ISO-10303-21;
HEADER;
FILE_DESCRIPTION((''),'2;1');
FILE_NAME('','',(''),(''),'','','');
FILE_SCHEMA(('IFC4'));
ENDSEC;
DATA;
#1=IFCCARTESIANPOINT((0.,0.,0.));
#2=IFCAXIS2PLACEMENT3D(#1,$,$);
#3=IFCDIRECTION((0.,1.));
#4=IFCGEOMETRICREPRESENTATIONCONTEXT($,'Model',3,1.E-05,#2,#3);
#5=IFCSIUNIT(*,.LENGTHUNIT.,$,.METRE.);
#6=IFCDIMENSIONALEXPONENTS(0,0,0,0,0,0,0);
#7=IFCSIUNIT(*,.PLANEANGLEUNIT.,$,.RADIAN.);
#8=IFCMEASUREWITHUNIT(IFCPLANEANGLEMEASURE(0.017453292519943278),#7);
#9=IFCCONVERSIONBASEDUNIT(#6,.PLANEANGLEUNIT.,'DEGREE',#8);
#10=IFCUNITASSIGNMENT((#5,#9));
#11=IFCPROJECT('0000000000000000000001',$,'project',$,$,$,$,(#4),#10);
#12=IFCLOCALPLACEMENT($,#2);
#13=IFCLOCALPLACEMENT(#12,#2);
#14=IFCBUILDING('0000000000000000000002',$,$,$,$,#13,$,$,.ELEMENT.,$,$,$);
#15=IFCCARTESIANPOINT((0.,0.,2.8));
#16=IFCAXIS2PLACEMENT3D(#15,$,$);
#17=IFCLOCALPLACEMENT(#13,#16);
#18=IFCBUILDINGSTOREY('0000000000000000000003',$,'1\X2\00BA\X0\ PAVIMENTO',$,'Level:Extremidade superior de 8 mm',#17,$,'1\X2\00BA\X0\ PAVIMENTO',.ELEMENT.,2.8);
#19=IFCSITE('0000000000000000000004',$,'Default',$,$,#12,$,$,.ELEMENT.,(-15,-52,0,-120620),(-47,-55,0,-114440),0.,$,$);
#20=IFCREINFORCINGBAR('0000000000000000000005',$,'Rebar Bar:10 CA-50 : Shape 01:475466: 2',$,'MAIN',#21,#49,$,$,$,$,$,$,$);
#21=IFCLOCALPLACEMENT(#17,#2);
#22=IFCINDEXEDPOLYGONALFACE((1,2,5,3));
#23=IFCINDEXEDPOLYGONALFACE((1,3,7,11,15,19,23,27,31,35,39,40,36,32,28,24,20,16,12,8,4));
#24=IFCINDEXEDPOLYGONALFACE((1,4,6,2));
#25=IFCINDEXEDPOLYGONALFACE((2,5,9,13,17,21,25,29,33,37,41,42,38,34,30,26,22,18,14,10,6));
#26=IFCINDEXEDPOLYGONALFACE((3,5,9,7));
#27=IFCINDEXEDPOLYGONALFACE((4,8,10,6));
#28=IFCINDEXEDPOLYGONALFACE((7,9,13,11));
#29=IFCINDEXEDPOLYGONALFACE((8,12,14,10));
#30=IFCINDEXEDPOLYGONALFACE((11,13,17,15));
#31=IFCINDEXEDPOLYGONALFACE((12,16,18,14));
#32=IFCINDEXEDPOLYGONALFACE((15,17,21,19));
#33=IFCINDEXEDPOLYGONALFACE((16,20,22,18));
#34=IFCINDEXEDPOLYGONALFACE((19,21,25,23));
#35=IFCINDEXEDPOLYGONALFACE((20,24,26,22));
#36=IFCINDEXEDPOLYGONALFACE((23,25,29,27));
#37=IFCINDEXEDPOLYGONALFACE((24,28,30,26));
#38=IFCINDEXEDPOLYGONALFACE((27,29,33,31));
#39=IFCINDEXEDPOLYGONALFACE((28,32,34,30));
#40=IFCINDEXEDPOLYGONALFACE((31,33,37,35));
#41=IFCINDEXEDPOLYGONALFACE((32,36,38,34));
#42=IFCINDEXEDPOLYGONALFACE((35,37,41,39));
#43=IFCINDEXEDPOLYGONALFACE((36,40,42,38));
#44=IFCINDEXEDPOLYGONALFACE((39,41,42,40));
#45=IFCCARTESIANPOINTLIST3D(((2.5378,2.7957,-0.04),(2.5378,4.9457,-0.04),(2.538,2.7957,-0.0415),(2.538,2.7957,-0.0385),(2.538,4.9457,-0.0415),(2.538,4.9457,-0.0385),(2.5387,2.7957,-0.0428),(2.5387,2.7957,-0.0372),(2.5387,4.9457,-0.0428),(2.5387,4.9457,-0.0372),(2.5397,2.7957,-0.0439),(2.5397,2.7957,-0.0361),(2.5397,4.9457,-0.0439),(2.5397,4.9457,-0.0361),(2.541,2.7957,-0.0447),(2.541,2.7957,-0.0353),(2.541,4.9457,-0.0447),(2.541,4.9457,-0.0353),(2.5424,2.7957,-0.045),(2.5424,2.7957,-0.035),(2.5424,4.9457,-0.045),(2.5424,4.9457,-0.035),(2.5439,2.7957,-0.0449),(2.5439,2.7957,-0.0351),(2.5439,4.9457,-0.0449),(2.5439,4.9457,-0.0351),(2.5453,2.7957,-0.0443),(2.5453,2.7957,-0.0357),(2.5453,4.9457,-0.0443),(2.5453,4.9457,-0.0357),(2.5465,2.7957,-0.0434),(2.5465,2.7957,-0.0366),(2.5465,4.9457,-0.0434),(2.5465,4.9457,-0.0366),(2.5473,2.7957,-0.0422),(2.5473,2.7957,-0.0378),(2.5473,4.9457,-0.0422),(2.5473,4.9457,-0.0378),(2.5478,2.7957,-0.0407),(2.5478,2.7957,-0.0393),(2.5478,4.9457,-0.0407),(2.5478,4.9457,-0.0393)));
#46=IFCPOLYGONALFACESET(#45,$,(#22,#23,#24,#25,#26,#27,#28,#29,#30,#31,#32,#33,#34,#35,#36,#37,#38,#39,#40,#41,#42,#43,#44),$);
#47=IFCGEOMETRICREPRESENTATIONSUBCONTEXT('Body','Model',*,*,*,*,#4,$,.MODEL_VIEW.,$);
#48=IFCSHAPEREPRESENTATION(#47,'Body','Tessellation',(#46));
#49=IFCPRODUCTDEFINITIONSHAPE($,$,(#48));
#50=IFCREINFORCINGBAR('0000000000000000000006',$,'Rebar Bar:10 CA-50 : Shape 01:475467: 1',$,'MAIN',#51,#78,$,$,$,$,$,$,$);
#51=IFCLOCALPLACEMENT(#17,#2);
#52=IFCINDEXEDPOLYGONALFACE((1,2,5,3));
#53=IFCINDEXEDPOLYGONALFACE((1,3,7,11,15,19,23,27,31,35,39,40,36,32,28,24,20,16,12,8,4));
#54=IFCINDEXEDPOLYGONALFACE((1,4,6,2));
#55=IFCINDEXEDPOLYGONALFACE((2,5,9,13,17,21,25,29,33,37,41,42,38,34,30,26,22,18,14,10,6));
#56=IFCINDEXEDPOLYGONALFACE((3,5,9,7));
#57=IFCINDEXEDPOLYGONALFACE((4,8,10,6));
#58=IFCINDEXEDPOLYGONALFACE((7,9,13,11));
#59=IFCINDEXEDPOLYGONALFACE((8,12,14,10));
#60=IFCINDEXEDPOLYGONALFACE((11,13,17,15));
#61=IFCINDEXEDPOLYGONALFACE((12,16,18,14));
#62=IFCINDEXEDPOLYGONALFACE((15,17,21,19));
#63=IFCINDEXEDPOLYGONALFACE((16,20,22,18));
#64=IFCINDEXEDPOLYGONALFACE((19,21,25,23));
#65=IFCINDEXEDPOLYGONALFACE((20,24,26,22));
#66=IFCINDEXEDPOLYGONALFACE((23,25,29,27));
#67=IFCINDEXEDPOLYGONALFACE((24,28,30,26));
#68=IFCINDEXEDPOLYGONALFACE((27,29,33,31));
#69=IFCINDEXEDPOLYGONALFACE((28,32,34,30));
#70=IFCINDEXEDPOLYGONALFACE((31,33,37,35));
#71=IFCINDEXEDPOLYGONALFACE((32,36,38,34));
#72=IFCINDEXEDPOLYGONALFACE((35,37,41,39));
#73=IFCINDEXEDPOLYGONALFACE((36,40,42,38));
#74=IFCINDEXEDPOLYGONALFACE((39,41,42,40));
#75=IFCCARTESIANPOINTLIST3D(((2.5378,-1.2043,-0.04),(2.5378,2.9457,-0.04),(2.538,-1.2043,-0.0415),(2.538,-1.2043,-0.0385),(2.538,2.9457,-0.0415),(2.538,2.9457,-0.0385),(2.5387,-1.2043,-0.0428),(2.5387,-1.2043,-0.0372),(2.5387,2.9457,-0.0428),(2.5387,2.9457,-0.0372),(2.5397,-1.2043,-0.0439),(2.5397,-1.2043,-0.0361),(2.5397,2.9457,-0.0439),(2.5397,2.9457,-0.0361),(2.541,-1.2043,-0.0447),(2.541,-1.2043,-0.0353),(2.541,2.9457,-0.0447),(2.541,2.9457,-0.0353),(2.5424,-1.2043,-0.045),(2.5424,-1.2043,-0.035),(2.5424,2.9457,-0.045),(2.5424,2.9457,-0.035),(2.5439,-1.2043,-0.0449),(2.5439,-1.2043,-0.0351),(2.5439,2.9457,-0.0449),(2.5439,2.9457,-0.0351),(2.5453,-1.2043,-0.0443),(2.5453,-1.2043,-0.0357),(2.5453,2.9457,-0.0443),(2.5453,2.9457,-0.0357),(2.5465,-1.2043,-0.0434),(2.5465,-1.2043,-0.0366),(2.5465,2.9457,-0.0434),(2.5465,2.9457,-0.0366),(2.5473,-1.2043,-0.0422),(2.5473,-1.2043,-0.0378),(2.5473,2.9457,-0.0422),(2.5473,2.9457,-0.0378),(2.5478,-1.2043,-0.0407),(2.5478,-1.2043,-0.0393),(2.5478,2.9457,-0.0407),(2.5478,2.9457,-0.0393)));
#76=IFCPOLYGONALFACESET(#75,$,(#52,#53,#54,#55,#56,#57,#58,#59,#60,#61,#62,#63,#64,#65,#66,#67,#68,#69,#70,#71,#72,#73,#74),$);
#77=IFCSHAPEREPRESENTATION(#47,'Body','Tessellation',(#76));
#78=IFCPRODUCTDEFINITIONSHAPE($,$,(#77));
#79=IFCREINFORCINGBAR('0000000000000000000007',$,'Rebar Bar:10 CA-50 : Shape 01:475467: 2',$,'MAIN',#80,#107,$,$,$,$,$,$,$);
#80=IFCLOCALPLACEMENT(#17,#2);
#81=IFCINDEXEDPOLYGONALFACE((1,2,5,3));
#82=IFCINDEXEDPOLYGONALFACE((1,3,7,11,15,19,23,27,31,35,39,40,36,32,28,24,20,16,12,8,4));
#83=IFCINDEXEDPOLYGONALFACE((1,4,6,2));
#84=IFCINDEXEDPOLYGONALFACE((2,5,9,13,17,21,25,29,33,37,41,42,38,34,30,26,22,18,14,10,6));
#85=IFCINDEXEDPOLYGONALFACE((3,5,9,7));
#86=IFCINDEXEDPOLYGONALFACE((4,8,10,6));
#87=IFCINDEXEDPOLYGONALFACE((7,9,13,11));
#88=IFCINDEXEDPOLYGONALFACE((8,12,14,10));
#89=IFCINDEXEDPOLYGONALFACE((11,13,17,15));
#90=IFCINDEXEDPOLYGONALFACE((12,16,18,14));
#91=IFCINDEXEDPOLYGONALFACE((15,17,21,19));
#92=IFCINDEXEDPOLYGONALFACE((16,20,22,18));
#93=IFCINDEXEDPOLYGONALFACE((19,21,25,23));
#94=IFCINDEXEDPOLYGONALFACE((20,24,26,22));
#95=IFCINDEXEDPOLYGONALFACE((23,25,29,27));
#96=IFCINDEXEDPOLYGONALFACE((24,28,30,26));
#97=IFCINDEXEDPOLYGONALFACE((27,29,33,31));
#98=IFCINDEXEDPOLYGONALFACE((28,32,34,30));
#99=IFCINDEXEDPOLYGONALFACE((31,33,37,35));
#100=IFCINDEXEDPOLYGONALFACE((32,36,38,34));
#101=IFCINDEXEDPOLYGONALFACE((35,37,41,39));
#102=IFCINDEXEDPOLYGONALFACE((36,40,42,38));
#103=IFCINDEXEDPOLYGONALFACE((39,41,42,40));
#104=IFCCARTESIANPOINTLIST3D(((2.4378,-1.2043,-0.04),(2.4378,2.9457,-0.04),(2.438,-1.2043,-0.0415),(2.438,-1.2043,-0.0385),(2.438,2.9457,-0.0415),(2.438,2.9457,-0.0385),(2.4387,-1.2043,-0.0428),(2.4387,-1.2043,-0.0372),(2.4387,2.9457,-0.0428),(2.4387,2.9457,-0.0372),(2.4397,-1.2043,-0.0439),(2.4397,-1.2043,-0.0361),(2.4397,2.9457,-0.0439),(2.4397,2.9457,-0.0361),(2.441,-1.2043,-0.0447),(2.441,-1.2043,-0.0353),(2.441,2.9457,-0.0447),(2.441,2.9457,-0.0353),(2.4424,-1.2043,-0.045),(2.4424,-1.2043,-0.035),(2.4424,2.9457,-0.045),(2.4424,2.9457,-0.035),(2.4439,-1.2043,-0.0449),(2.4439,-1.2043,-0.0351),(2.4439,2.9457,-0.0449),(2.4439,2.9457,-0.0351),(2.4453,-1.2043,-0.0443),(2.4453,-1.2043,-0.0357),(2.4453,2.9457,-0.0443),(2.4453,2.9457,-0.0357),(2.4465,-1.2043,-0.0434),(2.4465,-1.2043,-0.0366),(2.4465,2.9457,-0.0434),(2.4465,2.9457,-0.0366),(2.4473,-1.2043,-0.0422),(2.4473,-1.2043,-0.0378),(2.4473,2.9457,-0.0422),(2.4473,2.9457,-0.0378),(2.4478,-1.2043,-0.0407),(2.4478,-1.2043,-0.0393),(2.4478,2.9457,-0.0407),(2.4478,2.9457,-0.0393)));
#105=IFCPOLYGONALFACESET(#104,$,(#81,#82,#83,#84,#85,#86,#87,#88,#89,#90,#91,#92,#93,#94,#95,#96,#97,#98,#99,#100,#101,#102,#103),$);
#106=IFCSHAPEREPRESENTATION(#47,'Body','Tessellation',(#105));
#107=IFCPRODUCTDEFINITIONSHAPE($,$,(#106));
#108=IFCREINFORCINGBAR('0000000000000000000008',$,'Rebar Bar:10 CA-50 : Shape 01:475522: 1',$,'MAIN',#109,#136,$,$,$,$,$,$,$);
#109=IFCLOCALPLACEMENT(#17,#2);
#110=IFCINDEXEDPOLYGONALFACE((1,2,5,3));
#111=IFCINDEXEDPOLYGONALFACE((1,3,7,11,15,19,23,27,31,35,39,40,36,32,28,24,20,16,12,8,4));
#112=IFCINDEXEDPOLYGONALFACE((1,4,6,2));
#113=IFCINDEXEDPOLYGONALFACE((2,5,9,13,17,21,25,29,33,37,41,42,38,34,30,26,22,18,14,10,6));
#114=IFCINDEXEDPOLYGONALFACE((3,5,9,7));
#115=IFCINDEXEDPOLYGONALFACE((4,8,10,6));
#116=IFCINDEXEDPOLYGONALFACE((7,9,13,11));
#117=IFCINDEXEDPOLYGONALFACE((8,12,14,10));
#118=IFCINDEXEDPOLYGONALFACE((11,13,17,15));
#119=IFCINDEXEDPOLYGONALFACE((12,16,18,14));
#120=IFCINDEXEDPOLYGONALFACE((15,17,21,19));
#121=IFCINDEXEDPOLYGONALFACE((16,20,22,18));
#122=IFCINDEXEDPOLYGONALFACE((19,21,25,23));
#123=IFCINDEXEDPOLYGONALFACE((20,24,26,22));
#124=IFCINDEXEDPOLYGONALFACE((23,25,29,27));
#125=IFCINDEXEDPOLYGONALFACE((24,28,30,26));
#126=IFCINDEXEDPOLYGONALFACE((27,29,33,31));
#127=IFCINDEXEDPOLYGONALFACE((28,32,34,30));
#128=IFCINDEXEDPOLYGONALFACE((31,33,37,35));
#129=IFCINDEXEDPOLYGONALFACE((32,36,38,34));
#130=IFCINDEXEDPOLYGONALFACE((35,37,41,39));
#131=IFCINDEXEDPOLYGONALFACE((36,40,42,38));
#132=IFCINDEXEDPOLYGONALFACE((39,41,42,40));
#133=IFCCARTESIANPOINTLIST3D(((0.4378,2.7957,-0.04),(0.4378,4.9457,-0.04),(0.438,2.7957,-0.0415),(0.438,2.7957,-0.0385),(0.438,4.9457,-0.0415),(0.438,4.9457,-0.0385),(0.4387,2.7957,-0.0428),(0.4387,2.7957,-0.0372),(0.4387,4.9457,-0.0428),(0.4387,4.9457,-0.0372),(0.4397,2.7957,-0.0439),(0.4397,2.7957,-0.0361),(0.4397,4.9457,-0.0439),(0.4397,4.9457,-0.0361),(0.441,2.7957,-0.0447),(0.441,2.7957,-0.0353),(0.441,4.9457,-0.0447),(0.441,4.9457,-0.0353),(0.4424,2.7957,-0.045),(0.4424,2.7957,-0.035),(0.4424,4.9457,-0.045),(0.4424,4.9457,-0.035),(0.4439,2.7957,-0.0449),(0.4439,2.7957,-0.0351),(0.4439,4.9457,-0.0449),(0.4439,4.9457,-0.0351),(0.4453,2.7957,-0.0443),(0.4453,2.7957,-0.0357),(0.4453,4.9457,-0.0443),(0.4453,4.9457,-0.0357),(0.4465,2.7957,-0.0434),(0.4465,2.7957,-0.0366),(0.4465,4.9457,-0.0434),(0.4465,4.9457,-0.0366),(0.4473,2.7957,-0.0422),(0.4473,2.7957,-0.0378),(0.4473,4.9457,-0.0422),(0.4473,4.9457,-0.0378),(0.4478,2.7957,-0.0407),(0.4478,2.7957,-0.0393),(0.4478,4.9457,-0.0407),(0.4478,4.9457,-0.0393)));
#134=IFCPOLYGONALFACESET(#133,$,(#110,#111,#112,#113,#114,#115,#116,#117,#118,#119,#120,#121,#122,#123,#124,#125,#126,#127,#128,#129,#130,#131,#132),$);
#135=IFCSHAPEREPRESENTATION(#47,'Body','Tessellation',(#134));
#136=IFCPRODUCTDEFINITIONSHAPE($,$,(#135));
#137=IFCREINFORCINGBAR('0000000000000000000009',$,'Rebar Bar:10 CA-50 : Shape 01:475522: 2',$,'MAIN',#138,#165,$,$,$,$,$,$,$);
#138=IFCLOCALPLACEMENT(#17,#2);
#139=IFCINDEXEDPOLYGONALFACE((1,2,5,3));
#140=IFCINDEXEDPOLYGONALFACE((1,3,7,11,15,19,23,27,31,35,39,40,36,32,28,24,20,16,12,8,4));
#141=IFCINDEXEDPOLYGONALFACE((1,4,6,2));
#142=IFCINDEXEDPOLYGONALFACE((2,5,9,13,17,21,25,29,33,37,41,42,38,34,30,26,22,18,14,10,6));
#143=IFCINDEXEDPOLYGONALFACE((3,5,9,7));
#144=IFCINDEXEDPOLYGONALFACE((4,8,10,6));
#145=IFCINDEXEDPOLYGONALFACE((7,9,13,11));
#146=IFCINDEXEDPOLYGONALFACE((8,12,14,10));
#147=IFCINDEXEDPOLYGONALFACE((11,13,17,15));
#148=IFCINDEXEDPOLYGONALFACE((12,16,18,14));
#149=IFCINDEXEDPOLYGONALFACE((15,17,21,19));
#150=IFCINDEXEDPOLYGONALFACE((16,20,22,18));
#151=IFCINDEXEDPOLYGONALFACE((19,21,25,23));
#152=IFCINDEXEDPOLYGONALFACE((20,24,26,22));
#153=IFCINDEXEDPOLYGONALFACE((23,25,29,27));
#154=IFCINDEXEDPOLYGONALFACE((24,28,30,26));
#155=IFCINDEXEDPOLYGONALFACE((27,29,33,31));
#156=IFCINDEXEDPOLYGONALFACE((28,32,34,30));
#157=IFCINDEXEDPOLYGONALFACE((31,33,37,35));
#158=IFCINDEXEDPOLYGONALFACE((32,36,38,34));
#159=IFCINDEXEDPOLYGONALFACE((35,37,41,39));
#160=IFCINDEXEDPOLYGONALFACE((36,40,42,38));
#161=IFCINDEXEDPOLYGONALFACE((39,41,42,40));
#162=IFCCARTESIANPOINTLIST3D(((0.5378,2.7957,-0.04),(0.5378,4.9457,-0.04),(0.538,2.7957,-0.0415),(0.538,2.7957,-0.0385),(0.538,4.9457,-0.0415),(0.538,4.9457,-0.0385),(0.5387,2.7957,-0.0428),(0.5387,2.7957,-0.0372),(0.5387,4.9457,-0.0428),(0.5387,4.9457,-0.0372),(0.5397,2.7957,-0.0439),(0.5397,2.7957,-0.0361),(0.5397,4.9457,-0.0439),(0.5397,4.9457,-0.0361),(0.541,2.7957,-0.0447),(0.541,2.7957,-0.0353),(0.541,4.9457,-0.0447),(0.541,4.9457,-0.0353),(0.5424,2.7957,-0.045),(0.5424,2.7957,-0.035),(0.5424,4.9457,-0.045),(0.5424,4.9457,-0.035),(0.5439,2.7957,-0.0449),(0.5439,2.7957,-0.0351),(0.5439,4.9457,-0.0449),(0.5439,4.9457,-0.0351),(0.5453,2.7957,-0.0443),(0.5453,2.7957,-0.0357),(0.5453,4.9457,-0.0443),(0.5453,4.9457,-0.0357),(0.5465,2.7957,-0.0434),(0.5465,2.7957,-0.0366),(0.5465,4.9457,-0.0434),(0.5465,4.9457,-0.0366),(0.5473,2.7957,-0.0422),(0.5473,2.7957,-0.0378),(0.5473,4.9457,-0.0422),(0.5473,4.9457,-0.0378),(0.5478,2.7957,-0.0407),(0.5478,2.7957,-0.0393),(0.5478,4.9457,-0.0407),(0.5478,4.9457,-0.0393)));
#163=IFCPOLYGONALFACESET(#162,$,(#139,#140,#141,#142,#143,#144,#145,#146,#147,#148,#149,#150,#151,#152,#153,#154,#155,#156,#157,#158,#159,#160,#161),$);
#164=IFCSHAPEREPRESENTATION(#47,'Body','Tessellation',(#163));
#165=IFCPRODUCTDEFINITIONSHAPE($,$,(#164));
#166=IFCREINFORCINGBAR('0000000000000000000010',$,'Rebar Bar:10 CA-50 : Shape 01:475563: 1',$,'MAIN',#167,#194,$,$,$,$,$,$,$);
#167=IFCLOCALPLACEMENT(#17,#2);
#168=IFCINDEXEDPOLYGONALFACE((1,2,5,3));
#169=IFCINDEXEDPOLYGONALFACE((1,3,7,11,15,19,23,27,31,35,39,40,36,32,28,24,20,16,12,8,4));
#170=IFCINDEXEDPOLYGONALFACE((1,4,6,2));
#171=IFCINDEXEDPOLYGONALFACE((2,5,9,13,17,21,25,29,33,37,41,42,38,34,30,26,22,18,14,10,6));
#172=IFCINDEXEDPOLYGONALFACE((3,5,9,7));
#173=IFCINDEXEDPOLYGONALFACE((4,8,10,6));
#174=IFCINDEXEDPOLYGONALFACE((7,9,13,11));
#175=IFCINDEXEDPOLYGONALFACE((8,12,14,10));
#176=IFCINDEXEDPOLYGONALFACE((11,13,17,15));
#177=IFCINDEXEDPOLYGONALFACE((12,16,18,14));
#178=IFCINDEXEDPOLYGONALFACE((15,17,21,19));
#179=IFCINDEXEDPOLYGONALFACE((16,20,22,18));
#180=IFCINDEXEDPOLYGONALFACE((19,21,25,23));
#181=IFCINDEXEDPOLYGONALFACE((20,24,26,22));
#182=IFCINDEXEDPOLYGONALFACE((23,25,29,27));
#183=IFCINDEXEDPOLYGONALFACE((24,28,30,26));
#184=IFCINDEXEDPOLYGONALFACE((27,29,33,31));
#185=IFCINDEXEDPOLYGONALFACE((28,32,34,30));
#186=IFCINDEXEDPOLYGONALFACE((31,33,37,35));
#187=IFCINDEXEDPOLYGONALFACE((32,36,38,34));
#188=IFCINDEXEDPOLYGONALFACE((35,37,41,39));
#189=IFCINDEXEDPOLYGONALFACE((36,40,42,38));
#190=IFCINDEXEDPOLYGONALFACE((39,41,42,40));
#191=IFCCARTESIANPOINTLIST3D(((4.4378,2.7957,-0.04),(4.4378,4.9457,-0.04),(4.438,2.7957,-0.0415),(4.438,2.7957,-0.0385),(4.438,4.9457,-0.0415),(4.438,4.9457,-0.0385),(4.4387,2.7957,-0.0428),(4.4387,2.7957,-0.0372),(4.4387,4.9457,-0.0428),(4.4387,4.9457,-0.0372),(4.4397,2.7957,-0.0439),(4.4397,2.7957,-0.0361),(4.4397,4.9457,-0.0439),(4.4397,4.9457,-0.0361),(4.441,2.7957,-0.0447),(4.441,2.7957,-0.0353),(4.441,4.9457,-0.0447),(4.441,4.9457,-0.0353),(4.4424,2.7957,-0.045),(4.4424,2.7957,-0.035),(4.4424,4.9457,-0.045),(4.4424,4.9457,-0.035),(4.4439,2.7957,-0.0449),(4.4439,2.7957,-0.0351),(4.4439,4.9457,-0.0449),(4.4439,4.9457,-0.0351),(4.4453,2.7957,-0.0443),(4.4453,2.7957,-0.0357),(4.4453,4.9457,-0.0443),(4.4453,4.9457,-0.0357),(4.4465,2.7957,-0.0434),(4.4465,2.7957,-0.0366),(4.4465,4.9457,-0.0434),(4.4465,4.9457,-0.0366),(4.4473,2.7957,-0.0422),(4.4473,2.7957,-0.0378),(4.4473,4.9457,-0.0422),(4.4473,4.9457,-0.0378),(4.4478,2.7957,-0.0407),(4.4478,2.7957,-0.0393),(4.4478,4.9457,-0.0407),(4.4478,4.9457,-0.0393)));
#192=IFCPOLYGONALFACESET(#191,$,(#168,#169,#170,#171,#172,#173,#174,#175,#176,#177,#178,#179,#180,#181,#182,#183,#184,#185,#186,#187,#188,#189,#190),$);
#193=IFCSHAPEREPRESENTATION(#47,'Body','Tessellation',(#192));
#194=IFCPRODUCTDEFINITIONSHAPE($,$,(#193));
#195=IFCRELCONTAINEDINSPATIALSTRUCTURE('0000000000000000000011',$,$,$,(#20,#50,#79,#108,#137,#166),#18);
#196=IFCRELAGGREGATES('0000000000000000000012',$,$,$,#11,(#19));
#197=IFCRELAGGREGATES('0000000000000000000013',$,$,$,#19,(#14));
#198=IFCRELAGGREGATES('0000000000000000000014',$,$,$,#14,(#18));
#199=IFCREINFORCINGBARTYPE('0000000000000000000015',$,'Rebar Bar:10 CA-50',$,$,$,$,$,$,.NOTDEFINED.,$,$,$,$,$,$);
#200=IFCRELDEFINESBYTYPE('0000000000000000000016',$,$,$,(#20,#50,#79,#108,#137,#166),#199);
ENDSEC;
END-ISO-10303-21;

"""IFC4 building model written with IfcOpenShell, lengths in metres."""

from ifc_helpers import new_model, entity, si_unit, converted_unit, direction, frame, origin, place, context, subcontext, project, spatial, type_object, element, save


model = new_model("IFC4")

# Units and contexts
model_context = context("Model", 3, precision=1e-05, world=origin(), true_north=direction((0.0, 1.0)))
body_context = subcontext(model_context, "Body", "Model", "MODEL_VIEW")
ifc_project = project(units=[si_unit("LENGTHUNIT", "METRE"), converted_unit("PLANEANGLEUNIT", "DEGREE", entity("IfcPlaneAngleMeasure", 0.017453292519943278), si_unit("PLANEANGLEUNIT", "RADIAN"), dimensions=[0, 0, 0, 0, 0, 0, 0])], contexts=[model_context])

# Site, building, storey
site_placement = place(None, origin())
site = spatial("IfcSite", under=ifc_project, at=site_placement, Name="Default", CompositionType="ELEMENT", RefLatitude=(-15, -52, 0, -120620), RefLongitude=(-47, -55, 0, -114440), RefElevation=0.0)
building_placement = place(site_placement, origin())
building = spatial("IfcBuilding", under=site, at=building_placement, CompositionType="ELEMENT")
storey_placement = place(building_placement, frame((0.0, 0.0, 2.8)))
storey = spatial("IfcBuildingStorey", under=building, at=storey_placement, Name="1º PAVIMENTO", ObjectType="Level:Extremidade superior de 8 mm", LongName="1º PAVIMENTO", CompositionType="ELEMENT", Elevation=2.8)

# Reinforcing bars
reinforcing_bar_type = type_object("IfcReinforcingBarType", Name="Rebar Bar:10 CA-50", PredefinedType="NOTDEFINED")
reinforcing_bar_1_placement = place(storey_placement, origin())
element("IfcReinforcingBar", 1, at=reinforcing_bar_1_placement, inside=storey, type_object=reinforcing_bar_type, Name="Rebar Bar:10 CA-50 : Shape 01:475466: 2", ObjectType="MAIN", context=body_context, shape_type="AdvancedSweptSolid", body=[
    entity("IfcSweptDiskSolid", entity("IfcIndexedPolyCurve", entity("IfcCartesianPointList3D", [[2.5428, 4.9457, -0.04], [2.5428, 2.7957, -0.04]]), None, False), 0.005, None, 0.0, 1.0),
])
reinforcing_bar_2_placement = place(storey_placement, origin())
element("IfcReinforcingBar", 2, at=reinforcing_bar_2_placement, inside=storey, type_object=reinforcing_bar_type, Name="Rebar Bar:10 CA-50 : Shape 01:475467: 1", ObjectType="MAIN", context=body_context, shape_type="AdvancedSweptSolid", body=[
    entity("IfcSweptDiskSolid", entity("IfcIndexedPolyCurve", entity("IfcCartesianPointList3D", [[2.5428, 2.9457, -0.04], [2.5428, -1.2043, -0.04]]), None, False), 0.005, None, 0.0, 1.0),
])
reinforcing_bar_3_placement = place(storey_placement, origin())
element("IfcReinforcingBar", 3, at=reinforcing_bar_3_placement, inside=storey, type_object=reinforcing_bar_type, Name="Rebar Bar:10 CA-50 : Shape 01:475467: 2", ObjectType="MAIN", context=body_context, shape_type="AdvancedSweptSolid", body=[
    entity("IfcSweptDiskSolid", entity("IfcIndexedPolyCurve", entity("IfcCartesianPointList3D", [[2.4428, 2.9457, -0.04], [2.4428, -1.2043, -0.04]]), None, False), 0.005, None, 0.0, 1.0),
])
reinforcing_bar_4_placement = place(storey_placement, origin())
element("IfcReinforcingBar", 4, at=reinforcing_bar_4_placement, inside=storey, type_object=reinforcing_bar_type, Name="Rebar Bar:10 CA-50 : Shape 01:475522: 1", ObjectType="MAIN", context=body_context, shape_type="AdvancedSweptSolid", body=[
    entity("IfcSweptDiskSolid", entity("IfcIndexedPolyCurve", entity("IfcCartesianPointList3D", [[0.4428, 4.9457, -0.04], [0.4428, 2.7957, -0.04]]), None, False), 0.005, None, 0.0, 1.0),
])
reinforcing_bar_5_placement = place(storey_placement, origin())
element("IfcReinforcingBar", 5, at=reinforcing_bar_5_placement, inside=storey, type_object=reinforcing_bar_type, Name="Rebar Bar:10 CA-50 : Shape 01:475522: 2", ObjectType="MAIN", context=body_context, shape_type="AdvancedSweptSolid", body=[
    entity("IfcSweptDiskSolid", entity("IfcIndexedPolyCurve", entity("IfcCartesianPointList3D", [[0.5428, 4.9457, -0.04], [0.5428, 2.7957, -0.04]]), None, False), 0.005, None, 0.0, 1.0),
])
reinforcing_bar_6_placement = place(storey_placement, origin())
element("IfcReinforcingBar", 6, at=reinforcing_bar_6_placement, inside=storey, type_object=reinforcing_bar_type, Name="Rebar Bar:10 CA-50 : Shape 01:475563: 1", ObjectType="MAIN", context=body_context, shape_type="AdvancedSweptSolid", body=[
    entity("IfcSweptDiskSolid", entity("IfcIndexedPolyCurve", entity("IfcCartesianPointList3D", [[4.4428, 4.9457, -0.04], [4.4428, 2.7957, -0.04]]), None, False), 0.005, None, 0.0, 1.0),
])

save(model, "model.ifc")
